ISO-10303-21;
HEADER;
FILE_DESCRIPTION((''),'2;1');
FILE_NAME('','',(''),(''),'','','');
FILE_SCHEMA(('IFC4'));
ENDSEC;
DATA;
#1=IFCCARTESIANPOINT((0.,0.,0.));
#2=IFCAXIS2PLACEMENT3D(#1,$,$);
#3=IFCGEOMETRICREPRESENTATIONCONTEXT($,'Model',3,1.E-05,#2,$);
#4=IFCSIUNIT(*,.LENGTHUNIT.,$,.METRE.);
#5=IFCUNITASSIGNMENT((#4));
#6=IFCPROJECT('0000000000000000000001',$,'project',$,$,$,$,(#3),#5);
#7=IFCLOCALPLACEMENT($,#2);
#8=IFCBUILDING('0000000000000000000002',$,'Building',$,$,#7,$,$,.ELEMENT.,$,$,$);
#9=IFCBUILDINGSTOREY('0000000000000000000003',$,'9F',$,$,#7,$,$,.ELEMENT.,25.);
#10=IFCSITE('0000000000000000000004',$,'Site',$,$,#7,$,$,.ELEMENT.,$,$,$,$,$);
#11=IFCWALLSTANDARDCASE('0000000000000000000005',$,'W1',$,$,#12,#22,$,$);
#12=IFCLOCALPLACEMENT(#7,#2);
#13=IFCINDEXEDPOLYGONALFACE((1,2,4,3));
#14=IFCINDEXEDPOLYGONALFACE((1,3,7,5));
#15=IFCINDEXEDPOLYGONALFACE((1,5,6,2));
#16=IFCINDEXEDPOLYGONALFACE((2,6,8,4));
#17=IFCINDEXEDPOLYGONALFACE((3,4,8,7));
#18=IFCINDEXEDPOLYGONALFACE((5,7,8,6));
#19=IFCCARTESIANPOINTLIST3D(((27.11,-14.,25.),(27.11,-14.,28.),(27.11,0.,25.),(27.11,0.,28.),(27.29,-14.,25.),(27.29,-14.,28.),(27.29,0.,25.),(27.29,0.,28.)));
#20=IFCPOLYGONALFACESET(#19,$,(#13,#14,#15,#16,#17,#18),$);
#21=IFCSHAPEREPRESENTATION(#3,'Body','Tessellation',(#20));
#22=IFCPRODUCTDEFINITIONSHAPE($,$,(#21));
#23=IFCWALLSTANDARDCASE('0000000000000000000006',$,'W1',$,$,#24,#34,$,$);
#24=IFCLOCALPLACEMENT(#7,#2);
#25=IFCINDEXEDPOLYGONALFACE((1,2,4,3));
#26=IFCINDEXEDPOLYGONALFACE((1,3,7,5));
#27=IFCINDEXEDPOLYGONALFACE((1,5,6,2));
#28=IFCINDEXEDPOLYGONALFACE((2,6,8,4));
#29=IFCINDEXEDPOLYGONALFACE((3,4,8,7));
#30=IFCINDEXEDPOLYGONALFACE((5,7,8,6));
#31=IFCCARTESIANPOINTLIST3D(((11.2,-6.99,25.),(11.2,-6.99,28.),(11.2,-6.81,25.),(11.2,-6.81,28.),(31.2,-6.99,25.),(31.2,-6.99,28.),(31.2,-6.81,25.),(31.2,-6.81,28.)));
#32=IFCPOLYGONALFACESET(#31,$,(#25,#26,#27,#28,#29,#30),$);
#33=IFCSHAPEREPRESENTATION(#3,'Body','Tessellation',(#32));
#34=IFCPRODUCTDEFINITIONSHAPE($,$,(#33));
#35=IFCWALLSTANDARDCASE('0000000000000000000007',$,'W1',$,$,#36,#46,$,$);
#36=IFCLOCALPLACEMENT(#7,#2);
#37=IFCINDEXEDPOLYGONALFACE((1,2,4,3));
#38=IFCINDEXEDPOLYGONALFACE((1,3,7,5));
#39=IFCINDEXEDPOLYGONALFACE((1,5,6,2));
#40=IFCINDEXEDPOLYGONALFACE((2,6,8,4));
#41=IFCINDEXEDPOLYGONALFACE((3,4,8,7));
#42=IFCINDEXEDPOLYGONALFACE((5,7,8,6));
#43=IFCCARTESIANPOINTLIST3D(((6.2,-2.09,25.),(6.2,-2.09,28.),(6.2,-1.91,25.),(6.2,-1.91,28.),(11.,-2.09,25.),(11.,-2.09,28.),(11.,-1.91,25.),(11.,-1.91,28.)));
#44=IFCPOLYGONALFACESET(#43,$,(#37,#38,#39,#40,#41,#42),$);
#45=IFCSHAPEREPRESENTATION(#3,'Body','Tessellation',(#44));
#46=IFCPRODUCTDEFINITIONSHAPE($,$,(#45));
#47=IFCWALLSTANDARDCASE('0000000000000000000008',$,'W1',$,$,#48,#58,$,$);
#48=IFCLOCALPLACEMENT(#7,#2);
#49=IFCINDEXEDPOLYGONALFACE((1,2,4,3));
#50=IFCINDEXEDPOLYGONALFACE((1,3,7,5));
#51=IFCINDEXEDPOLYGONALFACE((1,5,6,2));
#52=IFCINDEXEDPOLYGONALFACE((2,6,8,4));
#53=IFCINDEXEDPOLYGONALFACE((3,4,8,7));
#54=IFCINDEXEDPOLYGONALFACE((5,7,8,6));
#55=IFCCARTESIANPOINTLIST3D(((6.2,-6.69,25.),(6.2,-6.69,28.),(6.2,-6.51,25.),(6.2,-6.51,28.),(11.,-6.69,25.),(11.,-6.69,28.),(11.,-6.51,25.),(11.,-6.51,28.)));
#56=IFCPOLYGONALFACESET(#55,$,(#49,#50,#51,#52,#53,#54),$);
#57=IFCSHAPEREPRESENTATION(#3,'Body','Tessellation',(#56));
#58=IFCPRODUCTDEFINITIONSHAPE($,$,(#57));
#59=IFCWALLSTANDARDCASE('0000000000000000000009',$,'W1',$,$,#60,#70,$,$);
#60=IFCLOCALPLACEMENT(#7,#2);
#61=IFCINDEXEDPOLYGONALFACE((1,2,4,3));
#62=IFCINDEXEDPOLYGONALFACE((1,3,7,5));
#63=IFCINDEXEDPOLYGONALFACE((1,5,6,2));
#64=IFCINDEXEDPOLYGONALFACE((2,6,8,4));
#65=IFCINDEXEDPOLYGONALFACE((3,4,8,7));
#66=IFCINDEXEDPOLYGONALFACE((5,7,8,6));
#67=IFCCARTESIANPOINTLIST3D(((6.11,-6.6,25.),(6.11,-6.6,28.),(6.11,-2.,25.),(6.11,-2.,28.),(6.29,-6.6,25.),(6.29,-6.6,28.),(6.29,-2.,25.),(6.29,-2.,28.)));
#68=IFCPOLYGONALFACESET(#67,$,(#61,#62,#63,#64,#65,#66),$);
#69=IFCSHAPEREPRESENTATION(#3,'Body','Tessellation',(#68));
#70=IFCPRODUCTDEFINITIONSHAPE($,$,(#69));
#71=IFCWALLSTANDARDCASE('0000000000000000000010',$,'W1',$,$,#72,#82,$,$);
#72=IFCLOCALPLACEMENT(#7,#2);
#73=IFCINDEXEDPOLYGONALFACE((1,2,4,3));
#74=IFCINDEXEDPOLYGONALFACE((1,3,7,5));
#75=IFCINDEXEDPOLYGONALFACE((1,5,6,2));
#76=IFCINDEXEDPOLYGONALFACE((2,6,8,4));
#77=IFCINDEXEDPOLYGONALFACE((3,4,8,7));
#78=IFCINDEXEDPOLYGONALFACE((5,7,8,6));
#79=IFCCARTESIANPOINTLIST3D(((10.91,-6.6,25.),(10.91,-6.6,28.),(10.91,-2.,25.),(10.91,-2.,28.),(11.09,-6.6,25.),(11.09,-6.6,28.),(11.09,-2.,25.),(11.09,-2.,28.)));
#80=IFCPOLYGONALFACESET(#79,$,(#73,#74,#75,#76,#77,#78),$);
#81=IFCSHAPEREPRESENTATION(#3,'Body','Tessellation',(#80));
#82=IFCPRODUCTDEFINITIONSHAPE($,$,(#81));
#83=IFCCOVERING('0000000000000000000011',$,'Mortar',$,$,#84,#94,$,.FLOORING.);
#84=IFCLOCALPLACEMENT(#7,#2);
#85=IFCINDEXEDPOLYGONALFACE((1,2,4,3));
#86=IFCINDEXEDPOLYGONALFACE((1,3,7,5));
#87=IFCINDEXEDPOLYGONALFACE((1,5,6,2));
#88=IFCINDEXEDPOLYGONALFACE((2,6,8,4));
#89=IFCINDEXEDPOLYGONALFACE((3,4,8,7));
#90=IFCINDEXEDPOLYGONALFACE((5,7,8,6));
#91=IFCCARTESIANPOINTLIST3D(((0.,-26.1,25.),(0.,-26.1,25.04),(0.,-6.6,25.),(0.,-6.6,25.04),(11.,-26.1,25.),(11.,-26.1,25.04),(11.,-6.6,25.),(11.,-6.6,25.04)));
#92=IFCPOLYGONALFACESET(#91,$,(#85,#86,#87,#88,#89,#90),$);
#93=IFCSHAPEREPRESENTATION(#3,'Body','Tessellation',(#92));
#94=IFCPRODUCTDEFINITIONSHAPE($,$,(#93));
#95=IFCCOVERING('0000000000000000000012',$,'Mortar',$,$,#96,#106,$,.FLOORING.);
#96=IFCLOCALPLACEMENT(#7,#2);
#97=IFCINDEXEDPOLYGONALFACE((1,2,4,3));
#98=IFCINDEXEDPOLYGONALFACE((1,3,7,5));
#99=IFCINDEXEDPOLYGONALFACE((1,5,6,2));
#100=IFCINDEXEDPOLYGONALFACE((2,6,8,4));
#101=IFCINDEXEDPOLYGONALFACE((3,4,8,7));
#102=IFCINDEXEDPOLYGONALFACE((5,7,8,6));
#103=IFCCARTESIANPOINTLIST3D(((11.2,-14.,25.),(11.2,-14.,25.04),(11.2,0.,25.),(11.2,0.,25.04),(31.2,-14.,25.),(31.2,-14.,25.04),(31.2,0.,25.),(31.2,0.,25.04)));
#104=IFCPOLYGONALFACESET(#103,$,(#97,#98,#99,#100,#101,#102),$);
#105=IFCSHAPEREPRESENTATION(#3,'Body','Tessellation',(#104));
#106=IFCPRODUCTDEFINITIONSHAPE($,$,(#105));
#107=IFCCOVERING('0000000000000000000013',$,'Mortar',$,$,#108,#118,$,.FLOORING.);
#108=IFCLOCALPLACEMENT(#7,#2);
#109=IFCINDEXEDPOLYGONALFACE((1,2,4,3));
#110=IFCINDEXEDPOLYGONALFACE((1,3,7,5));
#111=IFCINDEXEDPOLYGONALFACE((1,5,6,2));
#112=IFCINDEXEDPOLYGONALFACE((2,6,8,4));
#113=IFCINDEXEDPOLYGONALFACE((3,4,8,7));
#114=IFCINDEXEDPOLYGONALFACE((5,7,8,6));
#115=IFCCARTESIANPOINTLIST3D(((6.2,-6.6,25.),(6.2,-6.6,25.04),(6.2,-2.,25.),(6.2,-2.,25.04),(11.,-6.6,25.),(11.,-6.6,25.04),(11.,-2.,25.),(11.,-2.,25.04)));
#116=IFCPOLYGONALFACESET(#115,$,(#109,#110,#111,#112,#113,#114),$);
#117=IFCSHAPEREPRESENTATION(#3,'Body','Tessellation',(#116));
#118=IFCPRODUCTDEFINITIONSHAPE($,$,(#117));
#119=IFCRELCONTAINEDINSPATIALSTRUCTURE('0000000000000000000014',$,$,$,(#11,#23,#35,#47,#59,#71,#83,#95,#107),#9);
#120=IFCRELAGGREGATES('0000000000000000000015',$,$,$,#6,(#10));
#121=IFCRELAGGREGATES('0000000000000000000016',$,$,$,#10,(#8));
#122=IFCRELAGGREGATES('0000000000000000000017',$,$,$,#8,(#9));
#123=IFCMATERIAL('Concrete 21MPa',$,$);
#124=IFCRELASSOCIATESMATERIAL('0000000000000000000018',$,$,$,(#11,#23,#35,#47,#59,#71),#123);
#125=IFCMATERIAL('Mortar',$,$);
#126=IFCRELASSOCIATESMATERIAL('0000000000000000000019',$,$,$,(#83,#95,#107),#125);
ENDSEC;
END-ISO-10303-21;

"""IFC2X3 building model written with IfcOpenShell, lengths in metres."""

from ifc_helpers import new_model, si_unit, frame, origin, origin_2d, place, context, project, spatial, rectangle, extrude, material, element, save


model = new_model("IFC2X3")

# Units and contexts
model_context = context("Model", 3, precision=1e-05, world=origin())
ifc_project = project(units=[si_unit("LENGTHUNIT", "METRE")], contexts=[model_context])

# Site, building, storey
placement = place(None, origin())
site = spatial("IfcSite", under=ifc_project, at=placement, Name="Site", CompositionType="ELEMENT")
building = spatial("IfcBuilding", under=site, at=placement, Name="Building", CompositionType="ELEMENT")
storey = spatial("IfcBuildingStorey", under=building, at=placement, Name="9F", CompositionType="ELEMENT", Elevation=25.0)

# Shared definitions
ifc_material_1 = material(Name="Concrete 21MPa")

# Walls
for number, where, name in (
    (1, (27.2, -7.0, 25.0), "W1"),
):
    element("IfcWallStandardCase", number, at=place(None, frame(where)), inside=storey, material=ifc_material_1, Name=name, context=model_context, shape_type="SweptSolid", body=[
        extrude(rectangle(XDim=0.18, YDim=14.0, at=origin_2d()), origin(), (0.0, 0.0, 1.0), 3.0),
    ])
wall_1_placement = place(None, frame((21.2, -6.9, 25.0)))
element("IfcWallStandardCase", 2, at=wall_1_placement, inside=storey, material=ifc_material_1, Name="W1", context=model_context, shape_type="SweptSolid", body=[
    extrude(rectangle(XDim=20.0, YDim=0.18, at=origin_2d()), origin(), (0.0, 0.0, 1.0), 3.0),
])
for number, where, name in (
    (3, (8.6, -2.0, 25.0), "W1"),
    (4, (8.6, -6.6, 25.0), "W1"),
):
    element("IfcWallStandardCase", number, at=place(None, frame(where)), inside=storey, material=ifc_material_1, Name=name, context=model_context, shape_type="SweptSolid", body=[
        extrude(rectangle(XDim=4.8, YDim=0.18, at=origin_2d()), origin(), (0.0, 0.0, 1.0), 3.0),
    ])
for number, where, name in (
    (5, (6.2, -4.3, 25.0), "W1"),
    (6, (11.0, -4.3, 25.0), "W1"),
):
    element("IfcWallStandardCase", number, at=place(None, frame(where)), inside=storey, material=ifc_material_1, Name=name, context=model_context, shape_type="SweptSolid", body=[
        extrude(rectangle(XDim=0.18, YDim=4.6, at=origin_2d()), origin(), (0.0, 0.0, 1.0), 3.0),
    ])

# Coverings
ifc_material_2 = material(Name="Mortar")
covering_1_placement = place(None, frame((5.5, -16.35, 25.0)))
element("IfcCovering", 7, at=covering_1_placement, inside=storey, material=ifc_material_2, Name="Mortar", PredefinedType="FLOORING", context=model_context, shape_type="SweptSolid", body=[
    extrude(rectangle(XDim=11.0, YDim=19.5, at=origin_2d()), origin(), (0.0, 0.0, 1.0), 0.04),
])
covering_2_placement = place(None, frame((21.2, -7.0, 25.0)))
element("IfcCovering", 8, at=covering_2_placement, inside=storey, material=ifc_material_2, Name="Mortar", PredefinedType="FLOORING", context=model_context, shape_type="SweptSolid", body=[
    extrude(rectangle(XDim=20.0, YDim=14.0, at=origin_2d()), origin(), (0.0, 0.0, 1.0), 0.04),
])
covering_3_placement = place(None, frame((8.6, -4.3, 25.0)))
element("IfcCovering", 9, at=covering_3_placement, inside=storey, material=ifc_material_2, Name="Mortar", PredefinedType="FLOORING", context=model_context, shape_type="SweptSolid", body=[
    extrude(rectangle(XDim=4.8, YDim=4.6, at=origin_2d()), origin(), (0.0, 0.0, 1.0), 0.04),
])

save(model, "model.ifc")
